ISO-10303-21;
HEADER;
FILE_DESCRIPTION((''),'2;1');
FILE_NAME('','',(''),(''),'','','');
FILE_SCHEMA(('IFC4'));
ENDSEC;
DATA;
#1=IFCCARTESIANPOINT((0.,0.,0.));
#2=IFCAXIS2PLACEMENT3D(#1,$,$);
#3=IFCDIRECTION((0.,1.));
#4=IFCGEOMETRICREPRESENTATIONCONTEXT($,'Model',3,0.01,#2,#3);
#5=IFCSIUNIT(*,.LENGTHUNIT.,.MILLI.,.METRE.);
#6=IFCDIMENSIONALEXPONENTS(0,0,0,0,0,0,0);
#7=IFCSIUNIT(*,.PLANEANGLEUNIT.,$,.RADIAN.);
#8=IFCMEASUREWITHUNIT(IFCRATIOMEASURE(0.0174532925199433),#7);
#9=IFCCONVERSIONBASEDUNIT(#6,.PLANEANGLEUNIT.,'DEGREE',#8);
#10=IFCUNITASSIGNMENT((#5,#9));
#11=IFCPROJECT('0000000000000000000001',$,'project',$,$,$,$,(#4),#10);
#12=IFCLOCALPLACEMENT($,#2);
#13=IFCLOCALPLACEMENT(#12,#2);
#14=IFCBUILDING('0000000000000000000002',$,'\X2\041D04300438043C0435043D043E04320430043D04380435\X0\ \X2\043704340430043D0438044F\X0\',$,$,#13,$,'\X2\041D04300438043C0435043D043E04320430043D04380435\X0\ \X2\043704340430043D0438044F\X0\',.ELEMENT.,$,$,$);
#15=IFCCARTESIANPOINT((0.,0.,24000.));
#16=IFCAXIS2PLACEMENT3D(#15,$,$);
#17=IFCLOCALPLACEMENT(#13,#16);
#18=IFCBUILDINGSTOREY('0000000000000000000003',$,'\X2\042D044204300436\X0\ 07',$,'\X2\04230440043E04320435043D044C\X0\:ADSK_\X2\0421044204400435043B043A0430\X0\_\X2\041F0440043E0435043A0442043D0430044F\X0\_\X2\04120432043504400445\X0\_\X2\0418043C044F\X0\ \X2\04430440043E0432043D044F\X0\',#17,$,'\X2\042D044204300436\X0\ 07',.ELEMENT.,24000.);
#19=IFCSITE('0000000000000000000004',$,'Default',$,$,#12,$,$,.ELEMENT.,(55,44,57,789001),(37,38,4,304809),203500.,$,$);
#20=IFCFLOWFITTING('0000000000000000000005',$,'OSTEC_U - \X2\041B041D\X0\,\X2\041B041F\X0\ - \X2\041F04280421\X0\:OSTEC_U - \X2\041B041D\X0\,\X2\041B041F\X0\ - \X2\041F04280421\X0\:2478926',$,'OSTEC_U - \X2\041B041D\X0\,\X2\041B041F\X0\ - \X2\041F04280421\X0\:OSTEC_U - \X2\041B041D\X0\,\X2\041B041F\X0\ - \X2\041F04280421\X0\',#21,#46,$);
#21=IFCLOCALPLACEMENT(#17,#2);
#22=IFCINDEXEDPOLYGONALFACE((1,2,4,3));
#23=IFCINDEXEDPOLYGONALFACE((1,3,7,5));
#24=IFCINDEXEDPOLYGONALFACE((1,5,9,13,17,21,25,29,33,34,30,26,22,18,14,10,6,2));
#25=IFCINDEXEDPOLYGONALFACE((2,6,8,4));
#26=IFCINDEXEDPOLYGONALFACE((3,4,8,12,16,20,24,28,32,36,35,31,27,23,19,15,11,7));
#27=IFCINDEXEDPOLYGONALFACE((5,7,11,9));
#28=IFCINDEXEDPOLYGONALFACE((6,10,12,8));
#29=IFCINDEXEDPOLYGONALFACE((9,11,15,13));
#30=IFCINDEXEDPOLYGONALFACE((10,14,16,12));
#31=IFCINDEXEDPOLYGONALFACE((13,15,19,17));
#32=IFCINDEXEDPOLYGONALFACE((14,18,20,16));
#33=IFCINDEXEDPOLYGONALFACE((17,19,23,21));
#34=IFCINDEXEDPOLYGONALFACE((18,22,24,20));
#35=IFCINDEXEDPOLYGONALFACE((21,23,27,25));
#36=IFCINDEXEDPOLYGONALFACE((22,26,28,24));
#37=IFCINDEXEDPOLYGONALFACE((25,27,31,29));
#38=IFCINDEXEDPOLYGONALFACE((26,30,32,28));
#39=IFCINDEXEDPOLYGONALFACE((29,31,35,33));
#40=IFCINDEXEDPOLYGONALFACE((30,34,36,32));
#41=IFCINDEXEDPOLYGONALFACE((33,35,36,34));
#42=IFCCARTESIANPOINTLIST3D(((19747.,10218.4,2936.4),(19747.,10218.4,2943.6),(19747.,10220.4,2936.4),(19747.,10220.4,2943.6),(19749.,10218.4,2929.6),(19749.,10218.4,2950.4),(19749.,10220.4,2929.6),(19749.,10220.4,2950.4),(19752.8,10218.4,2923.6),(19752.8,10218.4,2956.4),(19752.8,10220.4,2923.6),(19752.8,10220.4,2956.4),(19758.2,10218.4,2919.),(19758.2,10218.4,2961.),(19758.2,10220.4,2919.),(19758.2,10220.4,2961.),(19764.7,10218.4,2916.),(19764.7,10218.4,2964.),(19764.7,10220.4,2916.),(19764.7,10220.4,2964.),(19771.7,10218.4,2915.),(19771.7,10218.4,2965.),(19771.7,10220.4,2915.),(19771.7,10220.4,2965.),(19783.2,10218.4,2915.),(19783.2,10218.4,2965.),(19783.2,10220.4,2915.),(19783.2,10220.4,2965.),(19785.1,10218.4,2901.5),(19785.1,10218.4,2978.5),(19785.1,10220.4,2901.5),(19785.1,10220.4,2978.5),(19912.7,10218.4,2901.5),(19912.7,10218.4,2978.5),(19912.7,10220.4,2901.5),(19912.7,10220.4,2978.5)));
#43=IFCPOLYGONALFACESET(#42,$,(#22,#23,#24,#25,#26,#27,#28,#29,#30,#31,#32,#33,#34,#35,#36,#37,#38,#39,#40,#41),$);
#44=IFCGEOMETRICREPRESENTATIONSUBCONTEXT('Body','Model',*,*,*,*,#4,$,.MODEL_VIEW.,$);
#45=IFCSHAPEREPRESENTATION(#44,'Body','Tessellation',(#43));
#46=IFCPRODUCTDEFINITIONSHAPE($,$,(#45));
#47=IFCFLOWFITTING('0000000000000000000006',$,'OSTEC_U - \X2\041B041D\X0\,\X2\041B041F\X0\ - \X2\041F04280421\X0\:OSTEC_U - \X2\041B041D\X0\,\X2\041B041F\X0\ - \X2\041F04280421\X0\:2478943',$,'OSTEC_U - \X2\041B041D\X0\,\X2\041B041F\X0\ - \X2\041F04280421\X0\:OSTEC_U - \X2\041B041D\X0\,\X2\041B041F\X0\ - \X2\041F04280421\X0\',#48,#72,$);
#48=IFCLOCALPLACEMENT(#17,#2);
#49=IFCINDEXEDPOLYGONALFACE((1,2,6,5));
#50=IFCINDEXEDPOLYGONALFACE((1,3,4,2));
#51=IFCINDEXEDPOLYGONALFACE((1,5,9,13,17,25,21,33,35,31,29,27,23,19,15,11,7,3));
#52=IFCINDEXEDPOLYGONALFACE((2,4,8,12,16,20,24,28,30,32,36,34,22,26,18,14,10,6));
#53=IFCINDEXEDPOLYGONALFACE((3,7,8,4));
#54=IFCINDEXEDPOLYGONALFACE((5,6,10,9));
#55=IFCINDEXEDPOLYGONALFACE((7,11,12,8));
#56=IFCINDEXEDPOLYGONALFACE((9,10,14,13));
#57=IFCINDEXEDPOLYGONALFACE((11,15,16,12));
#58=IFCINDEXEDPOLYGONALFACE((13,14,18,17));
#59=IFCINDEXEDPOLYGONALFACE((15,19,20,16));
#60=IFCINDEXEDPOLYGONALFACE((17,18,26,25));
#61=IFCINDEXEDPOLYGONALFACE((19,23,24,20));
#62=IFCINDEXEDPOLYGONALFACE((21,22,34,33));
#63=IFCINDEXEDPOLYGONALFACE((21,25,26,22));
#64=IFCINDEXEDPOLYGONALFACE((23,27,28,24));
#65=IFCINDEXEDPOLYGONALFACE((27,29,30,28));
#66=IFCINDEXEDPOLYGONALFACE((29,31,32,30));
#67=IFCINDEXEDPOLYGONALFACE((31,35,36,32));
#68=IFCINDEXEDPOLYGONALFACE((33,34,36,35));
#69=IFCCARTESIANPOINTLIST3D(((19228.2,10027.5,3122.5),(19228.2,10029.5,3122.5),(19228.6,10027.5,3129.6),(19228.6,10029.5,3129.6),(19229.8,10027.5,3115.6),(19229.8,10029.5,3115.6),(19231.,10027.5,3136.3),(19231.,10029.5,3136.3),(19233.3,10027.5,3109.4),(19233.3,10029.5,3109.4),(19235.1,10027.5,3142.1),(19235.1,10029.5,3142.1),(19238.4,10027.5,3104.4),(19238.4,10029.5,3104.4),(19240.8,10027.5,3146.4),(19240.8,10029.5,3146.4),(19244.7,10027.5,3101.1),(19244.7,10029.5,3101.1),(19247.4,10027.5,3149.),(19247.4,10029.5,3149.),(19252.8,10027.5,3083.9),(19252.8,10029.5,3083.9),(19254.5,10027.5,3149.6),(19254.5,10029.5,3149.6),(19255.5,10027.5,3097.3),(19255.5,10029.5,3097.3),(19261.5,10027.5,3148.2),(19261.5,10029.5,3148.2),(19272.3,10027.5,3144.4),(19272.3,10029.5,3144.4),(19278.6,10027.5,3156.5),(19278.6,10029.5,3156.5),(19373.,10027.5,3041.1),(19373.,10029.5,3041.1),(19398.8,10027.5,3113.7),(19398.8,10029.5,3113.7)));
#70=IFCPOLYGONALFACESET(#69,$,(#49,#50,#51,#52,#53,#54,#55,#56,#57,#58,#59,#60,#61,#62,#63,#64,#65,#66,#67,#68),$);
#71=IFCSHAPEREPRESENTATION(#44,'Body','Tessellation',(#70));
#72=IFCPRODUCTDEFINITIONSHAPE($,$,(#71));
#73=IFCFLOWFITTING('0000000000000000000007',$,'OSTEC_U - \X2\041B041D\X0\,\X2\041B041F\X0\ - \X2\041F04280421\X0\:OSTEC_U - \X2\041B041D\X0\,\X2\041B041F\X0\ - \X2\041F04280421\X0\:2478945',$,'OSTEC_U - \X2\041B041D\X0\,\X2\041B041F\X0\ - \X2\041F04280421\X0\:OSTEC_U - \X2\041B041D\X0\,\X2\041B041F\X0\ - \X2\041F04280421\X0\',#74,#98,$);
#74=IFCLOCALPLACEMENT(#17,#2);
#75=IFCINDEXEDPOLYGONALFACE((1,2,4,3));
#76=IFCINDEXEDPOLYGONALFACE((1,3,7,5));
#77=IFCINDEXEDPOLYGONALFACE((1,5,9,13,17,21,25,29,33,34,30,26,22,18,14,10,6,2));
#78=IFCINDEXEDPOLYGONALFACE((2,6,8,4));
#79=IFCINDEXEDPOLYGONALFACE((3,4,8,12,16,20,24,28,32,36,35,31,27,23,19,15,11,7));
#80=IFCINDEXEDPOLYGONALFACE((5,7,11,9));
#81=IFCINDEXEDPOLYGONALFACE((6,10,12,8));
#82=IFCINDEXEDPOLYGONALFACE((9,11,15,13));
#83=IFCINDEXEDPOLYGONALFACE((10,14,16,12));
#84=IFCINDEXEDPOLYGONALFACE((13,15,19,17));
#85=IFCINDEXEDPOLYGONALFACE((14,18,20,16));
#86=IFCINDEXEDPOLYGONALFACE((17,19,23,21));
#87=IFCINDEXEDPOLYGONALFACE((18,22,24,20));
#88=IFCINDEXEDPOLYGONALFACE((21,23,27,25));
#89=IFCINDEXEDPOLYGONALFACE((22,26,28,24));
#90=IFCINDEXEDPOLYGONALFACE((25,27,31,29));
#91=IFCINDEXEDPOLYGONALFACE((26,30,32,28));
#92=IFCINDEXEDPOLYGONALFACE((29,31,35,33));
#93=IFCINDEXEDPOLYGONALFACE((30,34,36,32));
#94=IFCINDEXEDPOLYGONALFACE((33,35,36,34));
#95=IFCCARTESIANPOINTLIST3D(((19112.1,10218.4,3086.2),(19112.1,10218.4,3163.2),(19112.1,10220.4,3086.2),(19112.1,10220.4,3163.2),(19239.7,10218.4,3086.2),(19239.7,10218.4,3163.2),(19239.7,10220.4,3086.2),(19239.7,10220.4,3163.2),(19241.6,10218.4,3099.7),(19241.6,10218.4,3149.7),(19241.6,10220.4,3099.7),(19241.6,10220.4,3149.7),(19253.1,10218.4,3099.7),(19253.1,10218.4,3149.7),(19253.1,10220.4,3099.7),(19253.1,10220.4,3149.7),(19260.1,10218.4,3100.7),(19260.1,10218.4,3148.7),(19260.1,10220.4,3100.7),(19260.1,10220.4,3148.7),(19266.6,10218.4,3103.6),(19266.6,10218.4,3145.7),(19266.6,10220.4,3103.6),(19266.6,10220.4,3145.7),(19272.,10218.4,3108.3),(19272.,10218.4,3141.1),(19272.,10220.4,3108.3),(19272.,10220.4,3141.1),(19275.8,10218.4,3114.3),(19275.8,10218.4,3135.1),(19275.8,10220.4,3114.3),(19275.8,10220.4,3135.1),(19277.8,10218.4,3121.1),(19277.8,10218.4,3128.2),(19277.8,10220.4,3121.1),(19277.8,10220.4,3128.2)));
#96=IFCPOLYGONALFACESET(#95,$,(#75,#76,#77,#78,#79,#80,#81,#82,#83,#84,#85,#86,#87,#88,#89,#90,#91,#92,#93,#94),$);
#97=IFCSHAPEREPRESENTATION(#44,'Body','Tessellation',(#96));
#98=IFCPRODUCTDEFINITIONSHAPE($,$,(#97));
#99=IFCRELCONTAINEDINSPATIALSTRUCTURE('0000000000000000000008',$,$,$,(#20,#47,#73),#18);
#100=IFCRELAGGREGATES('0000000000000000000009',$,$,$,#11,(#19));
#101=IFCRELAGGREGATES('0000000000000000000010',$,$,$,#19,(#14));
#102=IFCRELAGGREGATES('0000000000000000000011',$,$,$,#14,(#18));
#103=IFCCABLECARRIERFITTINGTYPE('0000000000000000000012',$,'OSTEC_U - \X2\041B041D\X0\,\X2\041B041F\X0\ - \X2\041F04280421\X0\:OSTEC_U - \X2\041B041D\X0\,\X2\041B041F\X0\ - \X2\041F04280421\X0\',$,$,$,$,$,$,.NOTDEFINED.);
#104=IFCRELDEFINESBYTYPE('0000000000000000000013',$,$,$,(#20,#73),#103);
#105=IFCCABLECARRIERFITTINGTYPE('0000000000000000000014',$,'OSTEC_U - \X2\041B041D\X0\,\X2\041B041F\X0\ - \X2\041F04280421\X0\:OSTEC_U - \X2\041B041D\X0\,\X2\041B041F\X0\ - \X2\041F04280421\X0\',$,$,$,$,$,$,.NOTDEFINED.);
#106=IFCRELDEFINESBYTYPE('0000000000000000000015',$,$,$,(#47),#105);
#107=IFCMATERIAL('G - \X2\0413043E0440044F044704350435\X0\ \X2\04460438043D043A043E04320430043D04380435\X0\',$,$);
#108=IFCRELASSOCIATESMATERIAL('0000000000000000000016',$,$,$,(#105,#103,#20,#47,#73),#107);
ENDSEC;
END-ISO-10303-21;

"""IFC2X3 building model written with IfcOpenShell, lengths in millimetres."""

from ifc_helpers import new_model, entity, si_unit, converted_unit, direction, frame, frame_2d, origin, place, context, subcontext, project, spatial, polyline, circle_curve, parameter, trimmed, segment, composite_curve, outline, extrude, source, transform, mapped, material, type_object, type_shapes, element, save


model = new_model("IFC2X3")

# Units and contexts
model_context = context("Model", 3, precision=0.01, world=origin(), true_north=direction((0.0, 1.0)))
body_context = subcontext(model_context, "Body", "Model", "MODEL_VIEW")
ifc_project = project(units=[si_unit("LENGTHUNIT", "METRE", prefix="MILLI"), converted_unit("PLANEANGLEUNIT", "DEGREE", entity("IfcRatioMeasure", 0.0174532925199433), si_unit("PLANEANGLEUNIT", "RADIAN"), dimensions=[0, 0, 0, 0, 0, 0, 0])], contexts=[model_context])

# Site, building, storey
site_placement = place(None, origin())
site = spatial("IfcSite", under=ifc_project, at=site_placement, Name="Default", CompositionType="ELEMENT", RefLatitude=(55, 44, 57, 789001), RefLongitude=(37, 38, 4, 304809), RefElevation=203500.0)
building_placement = place(site_placement, origin())
building = spatial("IfcBuilding", under=site, at=building_placement, Name="Наименование здания", LongName="Наименование здания", CompositionType="ELEMENT")
storey_placement = place(building_placement, frame((0.0, 0.0, 24000.0)))
storey = spatial("IfcBuildingStorey", under=building, at=storey_placement, Name="Этаж 07", ObjectType="Уровень:ADSK_Стрелка_Проектная_Вверх_Имя уровня", LongName="Этаж 07", CompositionType="ELEMENT", Elevation=24000.0)

# Flow fittings
ifc_material = material(Name="G - Горячее цинкование")
cable_carrier_fitting_type_1 = type_object("IfcCableCarrierFittingType", Name="OSTEC_U - ЛН,ЛП - ПШС:OSTEC_U - ЛН,ЛП - ПШС", PredefinedType="NOTDEFINED", material=ifc_material)
shared_shape_1 = source(origin(), body_context, "Body", "SweptSolid", [
    extrude(outline(composite_curve([segment(trimmed(circle_curve(frame_2d((-41.5, 0.0), x_axis=(1.0, 0.0)), 25.0), [parameter(90.0)], [parameter(270.0)], True, "PARAMETER"), True, "CONTINUOUS"), segment(polyline([(-41.5, -25.0), (-30.0, -25.0)]), True, "CONTINUOUS"), segment(polyline([(-30.0, -25.0), (-28.1, -38.5)]), True, "CONTINUOUS"), segment(polyline([(-28.1, -38.5), (99.5, -38.5)]), True, "CONTINUOUS"), segment(polyline([(99.5, -38.5), (99.5, 38.5)]), True, "CONTINUOUS"), segment(polyline([(99.5, 38.5), (-28.1, 38.5)]), True, "CONTINUOUS"), segment(polyline([(-28.1, 38.5), (-30.0, 25.0)]), True, "CONTINUOUS"), segment(polyline([(-30.0, 25.0), (-41.5, 25.0)]), True, "CONTINUOUS")], self_intersect=False)), frame((41.5, 0.0, 0.0)), (0.0, 0.0, 1.0), 2.0),
])
type_shapes(cable_carrier_fitting_type_1, [shared_shape_1])
cable_carrier_fitting_type_2 = type_object("IfcCableCarrierFittingType", Name="OSTEC_U - ЛН,ЛП - ПШС:OSTEC_U - ЛН,ЛП - ПШС", PredefinedType="NOTDEFINED", material=ifc_material)
type_shapes(cable_carrier_fitting_type_2, [shared_shape_1])
flow_fitting_1_placement = place(storey_placement, frame((19771.7, 10218.4, 2940.0), z_axis=(0.0, 1.0, 0.0), x_axis=(1.0, 0.0, 0.0)))
element("IfcFlowFitting", 1, at=flow_fitting_1_placement, inside=storey, type_object=cable_carrier_fitting_type_2, material=ifc_material, Name="OSTEC_U - ЛН,ЛП - ПШС:OSTEC_U - ЛН,ЛП - ПШС:2478926", ObjectType="OSTEC_U - ЛН,ЛП - ПШС:OSTEC_U - ЛН,ЛП - ПШС", context=body_context, shape_type="MappedRepresentation", body=[
    mapped(shared_shape_1, transform((0.0, 0.0, 0.0), scale=1.0)),
])
flow_fitting_2_placement = place(storey_placement, frame((19253.1, 10029.5, 3124.7), z_axis=(0.0, -1.0, 0.0), x_axis=(0.942059, 0.0, -0.335447)))
element("IfcFlowFitting", 2, at=flow_fitting_2_placement, inside=storey, type_object=cable_carrier_fitting_type_1, material=ifc_material, Name="OSTEC_U - ЛН,ЛП - ПШС:OSTEC_U - ЛН,ЛП - ПШС:2478943", ObjectType="OSTEC_U - ЛН,ЛП - ПШС:OSTEC_U - ЛН,ЛП - ПШС", context=body_context, shape_type="MappedRepresentation", body=[
    mapped(shared_shape_1, transform((0.0, 0.0, 0.0), scale=1.0)),
])
flow_fitting_3_placement = place(storey_placement, frame((19253.1, 10218.4, 3124.7), z_axis=(0.0, 1.0, 0.0), x_axis=(-1.0, 0.0, 0.0)))
element("IfcFlowFitting", 3, at=flow_fitting_3_placement, inside=storey, type_object=cable_carrier_fitting_type_2, material=ifc_material, Name="OSTEC_U - ЛН,ЛП - ПШС:OSTEC_U - ЛН,ЛП - ПШС:2478945", ObjectType="OSTEC_U - ЛН,ЛП - ПШС:OSTEC_U - ЛН,ЛП - ПШС", context=body_context, shape_type="MappedRepresentation", body=[
    mapped(shared_shape_1, transform((0.0, 0.0, 0.0), scale=1.0)),
])

save(model, "model.ifc")
